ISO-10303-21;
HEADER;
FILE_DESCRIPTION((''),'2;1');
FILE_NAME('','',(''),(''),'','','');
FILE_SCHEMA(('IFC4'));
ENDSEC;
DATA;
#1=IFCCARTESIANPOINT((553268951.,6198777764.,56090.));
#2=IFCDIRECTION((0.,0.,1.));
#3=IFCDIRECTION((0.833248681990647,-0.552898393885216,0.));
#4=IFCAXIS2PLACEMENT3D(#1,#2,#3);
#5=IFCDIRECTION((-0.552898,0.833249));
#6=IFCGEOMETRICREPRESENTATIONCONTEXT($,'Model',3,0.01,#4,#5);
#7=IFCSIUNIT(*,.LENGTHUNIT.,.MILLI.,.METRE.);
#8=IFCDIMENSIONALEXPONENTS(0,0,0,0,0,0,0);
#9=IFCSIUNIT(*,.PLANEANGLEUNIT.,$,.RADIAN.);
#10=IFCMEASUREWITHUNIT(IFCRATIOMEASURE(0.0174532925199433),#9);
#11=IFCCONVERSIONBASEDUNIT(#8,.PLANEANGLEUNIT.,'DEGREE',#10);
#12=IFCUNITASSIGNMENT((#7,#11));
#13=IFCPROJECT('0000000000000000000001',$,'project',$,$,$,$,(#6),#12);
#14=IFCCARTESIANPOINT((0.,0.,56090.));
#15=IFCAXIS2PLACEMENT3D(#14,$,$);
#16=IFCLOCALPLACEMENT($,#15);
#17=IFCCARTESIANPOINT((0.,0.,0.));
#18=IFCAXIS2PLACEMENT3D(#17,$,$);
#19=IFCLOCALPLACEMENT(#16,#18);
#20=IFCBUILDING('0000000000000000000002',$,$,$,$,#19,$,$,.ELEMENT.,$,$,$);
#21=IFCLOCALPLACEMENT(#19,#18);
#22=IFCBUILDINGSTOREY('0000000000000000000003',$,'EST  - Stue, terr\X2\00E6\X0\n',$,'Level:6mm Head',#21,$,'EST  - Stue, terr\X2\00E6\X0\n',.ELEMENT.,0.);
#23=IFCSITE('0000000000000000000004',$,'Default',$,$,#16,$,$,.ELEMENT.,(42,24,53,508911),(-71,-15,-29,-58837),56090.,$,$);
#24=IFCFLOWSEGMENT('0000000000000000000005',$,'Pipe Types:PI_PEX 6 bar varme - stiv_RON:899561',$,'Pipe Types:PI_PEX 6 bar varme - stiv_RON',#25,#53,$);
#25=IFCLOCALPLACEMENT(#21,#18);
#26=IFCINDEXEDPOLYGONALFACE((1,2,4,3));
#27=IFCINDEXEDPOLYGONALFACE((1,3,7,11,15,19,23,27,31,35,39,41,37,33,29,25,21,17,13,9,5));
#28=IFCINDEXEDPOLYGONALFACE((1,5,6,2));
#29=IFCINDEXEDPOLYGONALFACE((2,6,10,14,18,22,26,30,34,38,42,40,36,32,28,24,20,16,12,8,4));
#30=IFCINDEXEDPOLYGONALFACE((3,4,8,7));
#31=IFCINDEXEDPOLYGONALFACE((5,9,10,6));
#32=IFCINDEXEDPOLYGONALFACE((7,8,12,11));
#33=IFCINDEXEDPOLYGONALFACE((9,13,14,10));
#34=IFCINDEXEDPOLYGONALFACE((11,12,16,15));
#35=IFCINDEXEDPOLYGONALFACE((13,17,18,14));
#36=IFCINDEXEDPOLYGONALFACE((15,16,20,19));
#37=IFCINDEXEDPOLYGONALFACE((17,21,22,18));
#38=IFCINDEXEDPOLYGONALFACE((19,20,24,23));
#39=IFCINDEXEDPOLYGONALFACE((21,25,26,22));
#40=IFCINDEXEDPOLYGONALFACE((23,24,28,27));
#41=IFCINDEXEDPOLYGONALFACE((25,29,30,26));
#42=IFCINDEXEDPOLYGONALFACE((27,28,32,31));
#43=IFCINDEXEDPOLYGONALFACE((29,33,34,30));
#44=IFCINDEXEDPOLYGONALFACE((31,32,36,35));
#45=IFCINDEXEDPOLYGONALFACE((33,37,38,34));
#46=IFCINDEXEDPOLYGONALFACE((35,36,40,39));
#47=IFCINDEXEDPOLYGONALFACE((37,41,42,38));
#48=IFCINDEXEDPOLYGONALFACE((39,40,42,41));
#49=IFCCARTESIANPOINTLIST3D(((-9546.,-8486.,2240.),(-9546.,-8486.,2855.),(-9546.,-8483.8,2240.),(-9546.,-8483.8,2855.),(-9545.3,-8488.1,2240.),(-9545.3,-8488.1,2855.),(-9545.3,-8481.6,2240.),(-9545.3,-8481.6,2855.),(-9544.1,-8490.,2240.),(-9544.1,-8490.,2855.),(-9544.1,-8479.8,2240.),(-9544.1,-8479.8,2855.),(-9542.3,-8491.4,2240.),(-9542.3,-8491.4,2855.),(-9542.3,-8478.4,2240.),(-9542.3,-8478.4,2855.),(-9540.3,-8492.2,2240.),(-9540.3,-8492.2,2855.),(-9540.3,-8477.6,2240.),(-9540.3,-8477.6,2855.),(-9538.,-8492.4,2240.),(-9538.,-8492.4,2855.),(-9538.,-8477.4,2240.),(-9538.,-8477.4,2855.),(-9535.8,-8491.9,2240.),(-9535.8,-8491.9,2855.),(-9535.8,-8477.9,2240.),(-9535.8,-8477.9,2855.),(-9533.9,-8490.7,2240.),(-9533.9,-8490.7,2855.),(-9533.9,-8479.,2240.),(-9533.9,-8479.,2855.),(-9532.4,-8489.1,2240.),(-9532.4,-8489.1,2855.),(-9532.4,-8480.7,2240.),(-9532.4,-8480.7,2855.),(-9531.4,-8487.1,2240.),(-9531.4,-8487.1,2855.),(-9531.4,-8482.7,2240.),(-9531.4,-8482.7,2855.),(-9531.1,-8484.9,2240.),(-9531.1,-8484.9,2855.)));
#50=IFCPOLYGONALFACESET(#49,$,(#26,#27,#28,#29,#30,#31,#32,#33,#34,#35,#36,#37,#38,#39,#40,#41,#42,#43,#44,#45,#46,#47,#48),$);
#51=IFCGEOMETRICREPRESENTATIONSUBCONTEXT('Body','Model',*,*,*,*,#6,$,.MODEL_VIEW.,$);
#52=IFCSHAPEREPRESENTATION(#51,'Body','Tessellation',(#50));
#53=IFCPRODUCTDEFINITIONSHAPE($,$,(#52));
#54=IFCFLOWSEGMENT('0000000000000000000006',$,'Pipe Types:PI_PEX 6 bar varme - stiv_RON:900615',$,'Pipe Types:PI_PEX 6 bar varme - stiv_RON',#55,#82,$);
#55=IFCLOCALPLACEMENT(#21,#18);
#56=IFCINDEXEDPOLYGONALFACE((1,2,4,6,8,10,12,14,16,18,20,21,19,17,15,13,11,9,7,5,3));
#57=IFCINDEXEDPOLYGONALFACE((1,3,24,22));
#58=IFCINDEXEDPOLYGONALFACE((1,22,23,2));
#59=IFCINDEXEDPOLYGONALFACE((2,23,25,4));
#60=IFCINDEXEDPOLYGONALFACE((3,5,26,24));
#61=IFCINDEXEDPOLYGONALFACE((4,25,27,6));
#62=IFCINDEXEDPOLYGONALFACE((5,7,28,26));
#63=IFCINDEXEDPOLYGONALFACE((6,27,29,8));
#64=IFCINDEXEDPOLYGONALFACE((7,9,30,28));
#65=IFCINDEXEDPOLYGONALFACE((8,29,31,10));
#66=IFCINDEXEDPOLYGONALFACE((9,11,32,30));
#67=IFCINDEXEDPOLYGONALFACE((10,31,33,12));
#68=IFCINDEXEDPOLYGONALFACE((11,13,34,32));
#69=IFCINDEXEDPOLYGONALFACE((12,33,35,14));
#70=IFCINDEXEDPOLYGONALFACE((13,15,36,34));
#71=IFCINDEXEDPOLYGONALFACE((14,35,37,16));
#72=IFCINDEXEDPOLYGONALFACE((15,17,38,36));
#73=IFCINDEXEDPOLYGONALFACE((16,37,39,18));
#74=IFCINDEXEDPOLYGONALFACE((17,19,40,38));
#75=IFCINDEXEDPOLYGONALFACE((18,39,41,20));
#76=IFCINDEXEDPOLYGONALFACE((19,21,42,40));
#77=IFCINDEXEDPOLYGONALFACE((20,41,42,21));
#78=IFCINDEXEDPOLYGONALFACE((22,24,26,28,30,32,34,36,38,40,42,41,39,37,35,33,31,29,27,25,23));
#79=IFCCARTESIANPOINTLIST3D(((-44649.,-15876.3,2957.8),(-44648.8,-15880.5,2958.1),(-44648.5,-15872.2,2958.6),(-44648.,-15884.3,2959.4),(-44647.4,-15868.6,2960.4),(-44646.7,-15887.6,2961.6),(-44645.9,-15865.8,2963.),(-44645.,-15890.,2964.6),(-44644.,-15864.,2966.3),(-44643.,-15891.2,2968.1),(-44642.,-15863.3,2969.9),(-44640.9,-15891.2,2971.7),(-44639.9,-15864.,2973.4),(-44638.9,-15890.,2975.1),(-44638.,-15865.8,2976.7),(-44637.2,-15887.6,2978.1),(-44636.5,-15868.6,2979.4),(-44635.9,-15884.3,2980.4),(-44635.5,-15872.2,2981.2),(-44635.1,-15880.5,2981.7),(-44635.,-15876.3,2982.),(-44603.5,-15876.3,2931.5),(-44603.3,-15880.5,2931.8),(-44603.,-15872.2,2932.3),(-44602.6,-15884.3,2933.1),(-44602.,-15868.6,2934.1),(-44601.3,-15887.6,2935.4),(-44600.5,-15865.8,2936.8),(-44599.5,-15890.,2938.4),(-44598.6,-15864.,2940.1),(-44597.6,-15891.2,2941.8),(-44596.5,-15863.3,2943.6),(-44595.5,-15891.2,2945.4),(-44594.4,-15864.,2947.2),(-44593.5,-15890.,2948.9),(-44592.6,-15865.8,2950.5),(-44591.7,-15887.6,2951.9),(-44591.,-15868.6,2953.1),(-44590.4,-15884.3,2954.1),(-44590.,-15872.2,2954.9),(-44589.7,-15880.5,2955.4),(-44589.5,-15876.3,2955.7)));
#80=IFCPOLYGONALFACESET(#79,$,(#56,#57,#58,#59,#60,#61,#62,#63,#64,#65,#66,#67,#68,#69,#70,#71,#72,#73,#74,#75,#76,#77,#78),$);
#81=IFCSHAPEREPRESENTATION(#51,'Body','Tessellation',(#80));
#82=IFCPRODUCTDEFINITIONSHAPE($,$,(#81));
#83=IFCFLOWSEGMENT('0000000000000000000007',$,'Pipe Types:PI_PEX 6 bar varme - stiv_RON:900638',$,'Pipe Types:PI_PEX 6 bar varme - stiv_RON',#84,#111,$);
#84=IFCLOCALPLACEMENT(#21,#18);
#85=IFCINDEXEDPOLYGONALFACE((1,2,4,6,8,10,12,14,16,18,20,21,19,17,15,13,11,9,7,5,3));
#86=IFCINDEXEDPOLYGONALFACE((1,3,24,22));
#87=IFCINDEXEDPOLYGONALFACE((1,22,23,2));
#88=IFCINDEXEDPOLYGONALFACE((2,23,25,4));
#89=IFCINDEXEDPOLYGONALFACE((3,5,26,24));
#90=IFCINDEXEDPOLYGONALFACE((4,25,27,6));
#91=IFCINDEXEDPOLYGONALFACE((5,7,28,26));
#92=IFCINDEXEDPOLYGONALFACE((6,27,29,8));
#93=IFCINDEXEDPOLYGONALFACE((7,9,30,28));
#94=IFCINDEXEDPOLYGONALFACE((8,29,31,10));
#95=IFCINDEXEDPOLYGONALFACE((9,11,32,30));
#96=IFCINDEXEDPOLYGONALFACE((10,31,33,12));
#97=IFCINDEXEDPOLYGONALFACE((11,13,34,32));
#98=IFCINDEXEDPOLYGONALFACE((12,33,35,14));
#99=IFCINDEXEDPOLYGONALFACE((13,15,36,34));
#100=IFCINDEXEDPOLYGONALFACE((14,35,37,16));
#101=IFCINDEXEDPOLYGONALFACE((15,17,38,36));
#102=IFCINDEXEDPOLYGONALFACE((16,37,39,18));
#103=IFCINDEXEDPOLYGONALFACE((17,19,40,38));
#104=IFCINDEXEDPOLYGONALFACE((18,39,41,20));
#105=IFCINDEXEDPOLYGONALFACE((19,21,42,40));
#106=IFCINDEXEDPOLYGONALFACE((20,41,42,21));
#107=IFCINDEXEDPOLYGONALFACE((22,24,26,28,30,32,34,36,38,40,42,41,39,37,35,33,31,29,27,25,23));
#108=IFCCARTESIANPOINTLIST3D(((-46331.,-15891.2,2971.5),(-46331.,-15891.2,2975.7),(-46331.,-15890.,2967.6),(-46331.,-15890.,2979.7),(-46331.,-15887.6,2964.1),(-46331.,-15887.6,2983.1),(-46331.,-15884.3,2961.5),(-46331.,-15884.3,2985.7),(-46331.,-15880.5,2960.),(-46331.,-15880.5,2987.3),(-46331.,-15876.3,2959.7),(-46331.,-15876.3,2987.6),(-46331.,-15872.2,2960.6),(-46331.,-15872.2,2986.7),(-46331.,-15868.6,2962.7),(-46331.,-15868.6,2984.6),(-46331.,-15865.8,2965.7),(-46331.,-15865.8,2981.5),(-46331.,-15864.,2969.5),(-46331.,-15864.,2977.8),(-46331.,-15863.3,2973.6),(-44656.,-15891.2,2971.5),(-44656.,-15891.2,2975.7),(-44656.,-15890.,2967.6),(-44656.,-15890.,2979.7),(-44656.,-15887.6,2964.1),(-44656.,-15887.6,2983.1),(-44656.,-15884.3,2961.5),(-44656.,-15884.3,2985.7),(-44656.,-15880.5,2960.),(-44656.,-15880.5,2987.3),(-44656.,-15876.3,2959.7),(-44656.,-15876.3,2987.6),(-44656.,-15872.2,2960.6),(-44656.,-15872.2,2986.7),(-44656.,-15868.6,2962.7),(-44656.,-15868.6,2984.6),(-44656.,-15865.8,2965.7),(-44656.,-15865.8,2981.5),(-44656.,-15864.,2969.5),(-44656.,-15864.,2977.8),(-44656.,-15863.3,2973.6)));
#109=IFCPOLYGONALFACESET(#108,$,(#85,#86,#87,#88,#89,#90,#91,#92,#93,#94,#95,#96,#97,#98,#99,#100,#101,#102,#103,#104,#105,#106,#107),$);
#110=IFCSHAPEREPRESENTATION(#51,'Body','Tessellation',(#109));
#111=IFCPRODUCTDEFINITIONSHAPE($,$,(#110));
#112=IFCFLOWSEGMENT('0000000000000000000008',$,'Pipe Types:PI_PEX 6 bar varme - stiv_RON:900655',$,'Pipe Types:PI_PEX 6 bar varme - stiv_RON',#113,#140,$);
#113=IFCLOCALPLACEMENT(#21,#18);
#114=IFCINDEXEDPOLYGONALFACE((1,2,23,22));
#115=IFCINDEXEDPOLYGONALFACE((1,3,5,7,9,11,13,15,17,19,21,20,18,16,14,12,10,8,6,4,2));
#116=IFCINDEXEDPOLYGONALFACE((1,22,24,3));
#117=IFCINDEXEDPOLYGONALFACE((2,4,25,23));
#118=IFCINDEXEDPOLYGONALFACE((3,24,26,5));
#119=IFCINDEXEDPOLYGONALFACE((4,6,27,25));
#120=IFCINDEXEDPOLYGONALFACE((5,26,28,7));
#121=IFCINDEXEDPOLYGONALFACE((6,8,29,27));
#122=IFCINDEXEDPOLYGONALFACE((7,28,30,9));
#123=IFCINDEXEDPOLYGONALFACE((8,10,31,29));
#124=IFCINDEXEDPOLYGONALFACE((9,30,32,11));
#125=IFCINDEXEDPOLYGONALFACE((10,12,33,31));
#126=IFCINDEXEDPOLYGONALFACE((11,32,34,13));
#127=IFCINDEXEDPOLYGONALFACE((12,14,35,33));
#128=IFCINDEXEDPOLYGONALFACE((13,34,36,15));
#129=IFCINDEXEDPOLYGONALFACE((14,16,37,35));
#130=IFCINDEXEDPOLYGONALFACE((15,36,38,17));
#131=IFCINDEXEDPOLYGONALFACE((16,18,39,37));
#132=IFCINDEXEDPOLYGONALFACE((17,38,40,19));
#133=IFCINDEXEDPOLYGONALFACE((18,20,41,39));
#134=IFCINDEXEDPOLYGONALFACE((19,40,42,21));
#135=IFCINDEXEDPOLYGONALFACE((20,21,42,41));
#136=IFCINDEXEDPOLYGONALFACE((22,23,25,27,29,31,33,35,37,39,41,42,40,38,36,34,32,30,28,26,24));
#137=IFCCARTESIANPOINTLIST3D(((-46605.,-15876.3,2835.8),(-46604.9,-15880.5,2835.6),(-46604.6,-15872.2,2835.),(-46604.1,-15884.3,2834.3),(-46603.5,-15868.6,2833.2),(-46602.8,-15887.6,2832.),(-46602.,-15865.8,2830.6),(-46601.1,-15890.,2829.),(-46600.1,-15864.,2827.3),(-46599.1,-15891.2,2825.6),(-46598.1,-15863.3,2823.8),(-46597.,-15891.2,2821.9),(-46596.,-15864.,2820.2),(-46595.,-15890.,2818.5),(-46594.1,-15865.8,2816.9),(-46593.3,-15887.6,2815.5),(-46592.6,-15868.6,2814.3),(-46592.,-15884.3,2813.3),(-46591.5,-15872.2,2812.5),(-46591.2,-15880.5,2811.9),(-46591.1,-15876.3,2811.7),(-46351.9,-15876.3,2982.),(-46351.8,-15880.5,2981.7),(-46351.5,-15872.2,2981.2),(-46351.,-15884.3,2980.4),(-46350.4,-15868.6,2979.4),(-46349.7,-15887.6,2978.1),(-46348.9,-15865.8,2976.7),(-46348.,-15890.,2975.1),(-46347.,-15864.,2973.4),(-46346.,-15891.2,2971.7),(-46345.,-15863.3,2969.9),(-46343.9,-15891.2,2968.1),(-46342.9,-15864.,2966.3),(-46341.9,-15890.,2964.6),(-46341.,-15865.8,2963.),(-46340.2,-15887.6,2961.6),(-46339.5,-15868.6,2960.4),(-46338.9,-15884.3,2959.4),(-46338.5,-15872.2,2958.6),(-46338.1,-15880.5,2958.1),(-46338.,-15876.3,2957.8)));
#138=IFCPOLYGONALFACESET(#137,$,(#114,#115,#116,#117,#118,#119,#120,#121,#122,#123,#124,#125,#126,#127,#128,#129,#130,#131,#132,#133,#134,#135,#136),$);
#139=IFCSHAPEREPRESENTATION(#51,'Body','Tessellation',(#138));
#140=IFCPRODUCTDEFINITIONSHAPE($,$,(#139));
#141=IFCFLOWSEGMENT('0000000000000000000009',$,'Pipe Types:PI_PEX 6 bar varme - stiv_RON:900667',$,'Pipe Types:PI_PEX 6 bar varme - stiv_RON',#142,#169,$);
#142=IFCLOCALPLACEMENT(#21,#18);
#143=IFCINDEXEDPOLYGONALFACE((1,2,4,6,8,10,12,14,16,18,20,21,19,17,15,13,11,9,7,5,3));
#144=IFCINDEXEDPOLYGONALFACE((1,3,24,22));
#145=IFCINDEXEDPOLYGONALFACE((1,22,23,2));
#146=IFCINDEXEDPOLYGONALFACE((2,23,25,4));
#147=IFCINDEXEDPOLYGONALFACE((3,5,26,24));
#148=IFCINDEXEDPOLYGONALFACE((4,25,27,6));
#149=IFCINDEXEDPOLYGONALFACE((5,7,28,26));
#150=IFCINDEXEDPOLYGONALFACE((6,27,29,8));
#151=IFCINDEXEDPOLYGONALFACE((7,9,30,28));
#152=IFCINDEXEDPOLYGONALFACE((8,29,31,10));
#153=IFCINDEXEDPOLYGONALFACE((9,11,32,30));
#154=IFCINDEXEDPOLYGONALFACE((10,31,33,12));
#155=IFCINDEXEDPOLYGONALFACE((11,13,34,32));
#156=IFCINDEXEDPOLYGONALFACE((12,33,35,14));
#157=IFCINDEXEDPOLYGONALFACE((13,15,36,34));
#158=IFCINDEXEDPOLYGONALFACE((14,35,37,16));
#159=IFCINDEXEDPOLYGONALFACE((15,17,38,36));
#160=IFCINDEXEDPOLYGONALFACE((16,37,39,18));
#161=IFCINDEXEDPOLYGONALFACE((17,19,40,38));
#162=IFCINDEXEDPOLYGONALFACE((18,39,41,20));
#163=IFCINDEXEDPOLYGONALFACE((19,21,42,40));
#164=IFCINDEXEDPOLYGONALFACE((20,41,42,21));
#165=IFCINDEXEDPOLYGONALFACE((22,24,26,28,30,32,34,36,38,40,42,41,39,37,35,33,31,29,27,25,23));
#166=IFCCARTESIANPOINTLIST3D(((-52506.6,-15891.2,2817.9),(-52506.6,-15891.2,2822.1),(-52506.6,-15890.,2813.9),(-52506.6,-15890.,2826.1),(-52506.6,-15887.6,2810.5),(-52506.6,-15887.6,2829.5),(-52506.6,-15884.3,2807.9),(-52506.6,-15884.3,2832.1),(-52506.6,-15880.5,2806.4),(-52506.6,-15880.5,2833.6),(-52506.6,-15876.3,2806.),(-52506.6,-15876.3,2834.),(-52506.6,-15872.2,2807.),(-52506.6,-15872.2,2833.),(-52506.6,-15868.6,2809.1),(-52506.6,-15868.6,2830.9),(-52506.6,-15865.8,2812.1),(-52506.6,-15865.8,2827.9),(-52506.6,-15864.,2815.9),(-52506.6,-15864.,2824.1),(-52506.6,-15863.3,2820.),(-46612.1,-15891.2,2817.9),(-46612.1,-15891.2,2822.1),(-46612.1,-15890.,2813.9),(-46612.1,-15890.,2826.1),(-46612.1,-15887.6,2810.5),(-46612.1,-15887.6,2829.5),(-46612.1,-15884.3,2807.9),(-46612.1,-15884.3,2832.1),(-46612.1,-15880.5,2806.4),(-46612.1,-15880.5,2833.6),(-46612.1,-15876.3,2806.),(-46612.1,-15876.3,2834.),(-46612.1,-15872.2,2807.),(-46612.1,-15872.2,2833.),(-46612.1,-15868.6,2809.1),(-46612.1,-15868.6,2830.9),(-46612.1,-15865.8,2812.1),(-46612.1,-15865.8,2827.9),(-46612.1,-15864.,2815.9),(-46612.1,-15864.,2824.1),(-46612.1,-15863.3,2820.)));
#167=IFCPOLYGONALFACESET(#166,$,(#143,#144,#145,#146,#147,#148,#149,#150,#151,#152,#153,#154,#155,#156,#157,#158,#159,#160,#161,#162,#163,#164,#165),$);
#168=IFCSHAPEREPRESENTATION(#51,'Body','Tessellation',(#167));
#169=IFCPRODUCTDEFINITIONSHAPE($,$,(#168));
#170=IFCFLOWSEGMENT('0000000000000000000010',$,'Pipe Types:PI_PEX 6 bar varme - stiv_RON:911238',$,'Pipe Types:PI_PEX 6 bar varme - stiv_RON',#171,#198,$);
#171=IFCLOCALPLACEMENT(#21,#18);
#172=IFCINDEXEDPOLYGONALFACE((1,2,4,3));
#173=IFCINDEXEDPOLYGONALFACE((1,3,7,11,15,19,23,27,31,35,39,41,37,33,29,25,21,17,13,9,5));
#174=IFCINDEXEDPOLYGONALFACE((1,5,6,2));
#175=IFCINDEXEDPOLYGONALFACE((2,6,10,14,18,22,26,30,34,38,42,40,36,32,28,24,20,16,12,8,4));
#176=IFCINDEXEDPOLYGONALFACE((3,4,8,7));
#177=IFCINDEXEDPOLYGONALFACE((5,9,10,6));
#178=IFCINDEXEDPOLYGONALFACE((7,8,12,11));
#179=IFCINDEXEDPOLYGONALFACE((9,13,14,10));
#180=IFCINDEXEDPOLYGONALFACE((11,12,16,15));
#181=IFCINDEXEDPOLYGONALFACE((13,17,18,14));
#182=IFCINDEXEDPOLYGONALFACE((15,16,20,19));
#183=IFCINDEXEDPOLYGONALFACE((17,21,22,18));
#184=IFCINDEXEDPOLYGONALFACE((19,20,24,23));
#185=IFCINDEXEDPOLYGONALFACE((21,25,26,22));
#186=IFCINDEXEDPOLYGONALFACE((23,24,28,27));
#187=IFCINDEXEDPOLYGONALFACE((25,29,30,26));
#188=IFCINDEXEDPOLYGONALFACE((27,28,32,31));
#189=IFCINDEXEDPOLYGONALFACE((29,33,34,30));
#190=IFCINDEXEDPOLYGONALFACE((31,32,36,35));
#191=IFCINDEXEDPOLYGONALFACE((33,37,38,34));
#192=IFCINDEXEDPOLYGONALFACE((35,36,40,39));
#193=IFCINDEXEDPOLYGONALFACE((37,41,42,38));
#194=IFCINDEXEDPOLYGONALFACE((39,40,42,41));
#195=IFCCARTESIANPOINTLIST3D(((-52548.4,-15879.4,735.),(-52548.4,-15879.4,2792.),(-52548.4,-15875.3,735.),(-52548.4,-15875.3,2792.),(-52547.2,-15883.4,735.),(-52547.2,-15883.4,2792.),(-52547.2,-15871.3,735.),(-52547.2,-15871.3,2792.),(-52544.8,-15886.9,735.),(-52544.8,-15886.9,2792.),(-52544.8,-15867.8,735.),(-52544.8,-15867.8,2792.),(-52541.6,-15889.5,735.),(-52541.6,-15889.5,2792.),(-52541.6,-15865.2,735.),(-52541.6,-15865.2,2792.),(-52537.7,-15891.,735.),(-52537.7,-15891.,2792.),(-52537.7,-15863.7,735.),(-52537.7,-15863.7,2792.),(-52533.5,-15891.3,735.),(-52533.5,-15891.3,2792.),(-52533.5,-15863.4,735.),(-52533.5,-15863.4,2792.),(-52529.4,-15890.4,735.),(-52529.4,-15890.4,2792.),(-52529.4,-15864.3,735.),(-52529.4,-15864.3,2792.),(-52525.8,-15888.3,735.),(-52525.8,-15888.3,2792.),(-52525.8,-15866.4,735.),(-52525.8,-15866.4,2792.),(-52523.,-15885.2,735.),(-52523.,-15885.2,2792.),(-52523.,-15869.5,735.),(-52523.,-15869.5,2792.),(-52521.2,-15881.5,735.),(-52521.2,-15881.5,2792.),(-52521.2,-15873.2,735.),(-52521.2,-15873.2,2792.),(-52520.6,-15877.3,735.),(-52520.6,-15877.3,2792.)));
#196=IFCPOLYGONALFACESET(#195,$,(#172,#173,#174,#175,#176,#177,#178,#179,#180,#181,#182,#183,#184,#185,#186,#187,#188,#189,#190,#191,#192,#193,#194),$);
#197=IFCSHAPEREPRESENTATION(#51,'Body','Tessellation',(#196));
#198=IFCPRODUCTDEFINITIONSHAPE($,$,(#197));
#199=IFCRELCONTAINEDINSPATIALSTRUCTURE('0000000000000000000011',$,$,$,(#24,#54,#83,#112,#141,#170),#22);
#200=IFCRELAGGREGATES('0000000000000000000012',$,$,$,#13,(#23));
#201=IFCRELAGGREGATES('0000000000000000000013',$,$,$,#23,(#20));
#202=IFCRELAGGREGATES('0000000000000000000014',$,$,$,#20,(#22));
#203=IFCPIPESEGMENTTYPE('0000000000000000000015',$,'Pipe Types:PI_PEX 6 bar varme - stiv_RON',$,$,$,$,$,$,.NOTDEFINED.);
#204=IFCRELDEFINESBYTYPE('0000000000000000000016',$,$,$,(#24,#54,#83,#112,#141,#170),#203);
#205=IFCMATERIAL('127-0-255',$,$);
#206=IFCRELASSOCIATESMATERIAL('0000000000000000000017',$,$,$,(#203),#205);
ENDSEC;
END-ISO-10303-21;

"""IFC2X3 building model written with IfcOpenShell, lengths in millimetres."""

from ifc_helpers import new_model, entity, si_unit, converted_unit, direction, frame, frame_2d, origin, origin_2d_with_axis, place, context, subcontext, project, spatial, circle, extrude, material, type_object, element, save


model = new_model("IFC2X3")

# Units and contexts
model_context = context("Model", 3, precision=0.01, world=frame((553268951.0, 6198777764.0, 56090.0), z_axis=(0.0, 0.0, 1.0), x_axis=(0.833248681990647, -0.552898393885216, 0.0)), true_north=direction((-0.552898, 0.833249)))
body_context = subcontext(model_context, "Body", "Model", "MODEL_VIEW")
ifc_project = project(units=[si_unit("LENGTHUNIT", "METRE", prefix="MILLI"), converted_unit("PLANEANGLEUNIT", "DEGREE", entity("IfcRatioMeasure", 0.0174532925199433), si_unit("PLANEANGLEUNIT", "RADIAN"), dimensions=[0, 0, 0, 0, 0, 0, 0])], contexts=[model_context])

# Site, building, storey
site_placement = place(None, frame((0.0, 0.0, 56090.0)))
site = spatial("IfcSite", under=ifc_project, at=site_placement, Name="Default", CompositionType="ELEMENT", RefLatitude=(42, 24, 53, 508911), RefLongitude=(-71, -15, -29, -58837), RefElevation=56090.0)
building_placement = place(site_placement, origin())
building = spatial("IfcBuilding", under=site, at=building_placement, CompositionType="ELEMENT")
storey_placement = place(building_placement, frame((0.0, 0.0, 0.0)))
storey = spatial("IfcBuildingStorey", under=building, at=storey_placement, Name="EST  - Stue, terræn", ObjectType="Level:6mm Head", LongName="EST  - Stue, terræn", CompositionType="ELEMENT", Elevation=0.0)

# Flow segments
ifc_material_1 = material(Name="127-0-255")
pipe_segment_type_1 = type_object("IfcPipeSegmentType", Name="Pipe Types:PI_PEX 6 bar varme - stiv_RON", PredefinedType="NOTDEFINED", material=ifc_material_1)
flow_segment_1_placement = place(storey_placement, origin())
element("IfcFlowSegment", 1, at=flow_segment_1_placement, inside=storey, type_object=pipe_segment_type_1, Name="Pipe Types:PI_PEX 6 bar varme - stiv_RON:899561", ObjectType="Pipe Types:PI_PEX 6 bar varme - stiv_RON", context=body_context, shape_type="SweptSolid", body=[
    extrude(circle(Radius=7.5, at=origin_2d_with_axis()), frame((-9538.6, -8484.9, 2240.0)), (0.0, 0.0, 1.0), 615.0),
])
flow_segment_2_placement = place(storey_placement, origin())
element("IfcFlowSegment", 2, at=flow_segment_2_placement, inside=storey, type_object=pipe_segment_type_1, Name="Pipe Types:PI_PEX 6 bar varme - stiv_RON:900615", ObjectType="Pipe Types:PI_PEX 6 bar varme - stiv_RON", context=body_context, shape_type="SweptSolid", body=[
    extrude(circle(Radius=14.0, at=origin_2d_with_axis()), frame((-44596.5, -15877.3, 2943.6), z_axis=(-0.866025, 0.0, 0.5), x_axis=(0.0, 1.0, 0.0)), (0.0, 0.0, 1.0), 52.5),
])
flow_segment_3_placement = place(storey_placement, origin())
element("IfcFlowSegment", 3, at=flow_segment_3_placement, inside=storey, type_object=pipe_segment_type_1, Name="Pipe Types:PI_PEX 6 bar varme - stiv_RON:900638", ObjectType="Pipe Types:PI_PEX 6 bar varme - stiv_RON", context=body_context, shape_type="SweptSolid", body=[
    extrude(circle(Radius=14.0, at=frame_2d((0.0, 0.0), x_axis=(1.0, 0.0))), frame((-46331.0, -15877.3, 2973.6), z_axis=(1.0, 0.0, 0.0), x_axis=(0.0, 1.0, 0.0)), (0.0, 0.0, 1.0), 1675.0),
])
flow_segment_4_placement = place(storey_placement, origin())
element("IfcFlowSegment", 4, at=flow_segment_4_placement, inside=storey, type_object=pipe_segment_type_1, Name="Pipe Types:PI_PEX 6 bar varme - stiv_RON:900655", ObjectType="Pipe Types:PI_PEX 6 bar varme - stiv_RON", context=body_context, shape_type="SweptSolid", body=[
    extrude(circle(Radius=14.0, at=origin_2d_with_axis()), frame((-46598.1, -15877.3, 2823.8), z_axis=(0.866025, 0.0, 0.5), x_axis=(0.0, 1.0, 0.0)), (0.0, 0.0, 1.0), 292.2),
])
flow_segment_5_placement = place(storey_placement, origin())
element("IfcFlowSegment", 5, at=flow_segment_5_placement, inside=storey, type_object=pipe_segment_type_1, Name="Pipe Types:PI_PEX 6 bar varme - stiv_RON:900667", ObjectType="Pipe Types:PI_PEX 6 bar varme - stiv_RON", context=body_context, shape_type="SweptSolid", body=[
    extrude(circle(Radius=14.0, at=frame_2d((0.0, 0.0), x_axis=(1.0, 0.0))), frame((-52506.6, -15877.3, 2820.0), z_axis=(1.0, 0.0, 0.0), x_axis=(0.0, 1.0, 0.0)), (0.0, 0.0, 1.0), 5894.5),
])
flow_segment_6_placement = place(storey_placement, origin())
element("IfcFlowSegment", 6, at=flow_segment_6_placement, inside=storey, type_object=pipe_segment_type_1, Name="Pipe Types:PI_PEX 6 bar varme - stiv_RON:911238", ObjectType="Pipe Types:PI_PEX 6 bar varme - stiv_RON", context=body_context, shape_type="SweptSolid", body=[
    extrude(circle(Radius=14.0, at=origin_2d_with_axis()), frame((-52534.6, -15877.3, 735.0)), (0.0, 0.0, 1.0), 2057.0),
])

save(model, "model.ifc")
